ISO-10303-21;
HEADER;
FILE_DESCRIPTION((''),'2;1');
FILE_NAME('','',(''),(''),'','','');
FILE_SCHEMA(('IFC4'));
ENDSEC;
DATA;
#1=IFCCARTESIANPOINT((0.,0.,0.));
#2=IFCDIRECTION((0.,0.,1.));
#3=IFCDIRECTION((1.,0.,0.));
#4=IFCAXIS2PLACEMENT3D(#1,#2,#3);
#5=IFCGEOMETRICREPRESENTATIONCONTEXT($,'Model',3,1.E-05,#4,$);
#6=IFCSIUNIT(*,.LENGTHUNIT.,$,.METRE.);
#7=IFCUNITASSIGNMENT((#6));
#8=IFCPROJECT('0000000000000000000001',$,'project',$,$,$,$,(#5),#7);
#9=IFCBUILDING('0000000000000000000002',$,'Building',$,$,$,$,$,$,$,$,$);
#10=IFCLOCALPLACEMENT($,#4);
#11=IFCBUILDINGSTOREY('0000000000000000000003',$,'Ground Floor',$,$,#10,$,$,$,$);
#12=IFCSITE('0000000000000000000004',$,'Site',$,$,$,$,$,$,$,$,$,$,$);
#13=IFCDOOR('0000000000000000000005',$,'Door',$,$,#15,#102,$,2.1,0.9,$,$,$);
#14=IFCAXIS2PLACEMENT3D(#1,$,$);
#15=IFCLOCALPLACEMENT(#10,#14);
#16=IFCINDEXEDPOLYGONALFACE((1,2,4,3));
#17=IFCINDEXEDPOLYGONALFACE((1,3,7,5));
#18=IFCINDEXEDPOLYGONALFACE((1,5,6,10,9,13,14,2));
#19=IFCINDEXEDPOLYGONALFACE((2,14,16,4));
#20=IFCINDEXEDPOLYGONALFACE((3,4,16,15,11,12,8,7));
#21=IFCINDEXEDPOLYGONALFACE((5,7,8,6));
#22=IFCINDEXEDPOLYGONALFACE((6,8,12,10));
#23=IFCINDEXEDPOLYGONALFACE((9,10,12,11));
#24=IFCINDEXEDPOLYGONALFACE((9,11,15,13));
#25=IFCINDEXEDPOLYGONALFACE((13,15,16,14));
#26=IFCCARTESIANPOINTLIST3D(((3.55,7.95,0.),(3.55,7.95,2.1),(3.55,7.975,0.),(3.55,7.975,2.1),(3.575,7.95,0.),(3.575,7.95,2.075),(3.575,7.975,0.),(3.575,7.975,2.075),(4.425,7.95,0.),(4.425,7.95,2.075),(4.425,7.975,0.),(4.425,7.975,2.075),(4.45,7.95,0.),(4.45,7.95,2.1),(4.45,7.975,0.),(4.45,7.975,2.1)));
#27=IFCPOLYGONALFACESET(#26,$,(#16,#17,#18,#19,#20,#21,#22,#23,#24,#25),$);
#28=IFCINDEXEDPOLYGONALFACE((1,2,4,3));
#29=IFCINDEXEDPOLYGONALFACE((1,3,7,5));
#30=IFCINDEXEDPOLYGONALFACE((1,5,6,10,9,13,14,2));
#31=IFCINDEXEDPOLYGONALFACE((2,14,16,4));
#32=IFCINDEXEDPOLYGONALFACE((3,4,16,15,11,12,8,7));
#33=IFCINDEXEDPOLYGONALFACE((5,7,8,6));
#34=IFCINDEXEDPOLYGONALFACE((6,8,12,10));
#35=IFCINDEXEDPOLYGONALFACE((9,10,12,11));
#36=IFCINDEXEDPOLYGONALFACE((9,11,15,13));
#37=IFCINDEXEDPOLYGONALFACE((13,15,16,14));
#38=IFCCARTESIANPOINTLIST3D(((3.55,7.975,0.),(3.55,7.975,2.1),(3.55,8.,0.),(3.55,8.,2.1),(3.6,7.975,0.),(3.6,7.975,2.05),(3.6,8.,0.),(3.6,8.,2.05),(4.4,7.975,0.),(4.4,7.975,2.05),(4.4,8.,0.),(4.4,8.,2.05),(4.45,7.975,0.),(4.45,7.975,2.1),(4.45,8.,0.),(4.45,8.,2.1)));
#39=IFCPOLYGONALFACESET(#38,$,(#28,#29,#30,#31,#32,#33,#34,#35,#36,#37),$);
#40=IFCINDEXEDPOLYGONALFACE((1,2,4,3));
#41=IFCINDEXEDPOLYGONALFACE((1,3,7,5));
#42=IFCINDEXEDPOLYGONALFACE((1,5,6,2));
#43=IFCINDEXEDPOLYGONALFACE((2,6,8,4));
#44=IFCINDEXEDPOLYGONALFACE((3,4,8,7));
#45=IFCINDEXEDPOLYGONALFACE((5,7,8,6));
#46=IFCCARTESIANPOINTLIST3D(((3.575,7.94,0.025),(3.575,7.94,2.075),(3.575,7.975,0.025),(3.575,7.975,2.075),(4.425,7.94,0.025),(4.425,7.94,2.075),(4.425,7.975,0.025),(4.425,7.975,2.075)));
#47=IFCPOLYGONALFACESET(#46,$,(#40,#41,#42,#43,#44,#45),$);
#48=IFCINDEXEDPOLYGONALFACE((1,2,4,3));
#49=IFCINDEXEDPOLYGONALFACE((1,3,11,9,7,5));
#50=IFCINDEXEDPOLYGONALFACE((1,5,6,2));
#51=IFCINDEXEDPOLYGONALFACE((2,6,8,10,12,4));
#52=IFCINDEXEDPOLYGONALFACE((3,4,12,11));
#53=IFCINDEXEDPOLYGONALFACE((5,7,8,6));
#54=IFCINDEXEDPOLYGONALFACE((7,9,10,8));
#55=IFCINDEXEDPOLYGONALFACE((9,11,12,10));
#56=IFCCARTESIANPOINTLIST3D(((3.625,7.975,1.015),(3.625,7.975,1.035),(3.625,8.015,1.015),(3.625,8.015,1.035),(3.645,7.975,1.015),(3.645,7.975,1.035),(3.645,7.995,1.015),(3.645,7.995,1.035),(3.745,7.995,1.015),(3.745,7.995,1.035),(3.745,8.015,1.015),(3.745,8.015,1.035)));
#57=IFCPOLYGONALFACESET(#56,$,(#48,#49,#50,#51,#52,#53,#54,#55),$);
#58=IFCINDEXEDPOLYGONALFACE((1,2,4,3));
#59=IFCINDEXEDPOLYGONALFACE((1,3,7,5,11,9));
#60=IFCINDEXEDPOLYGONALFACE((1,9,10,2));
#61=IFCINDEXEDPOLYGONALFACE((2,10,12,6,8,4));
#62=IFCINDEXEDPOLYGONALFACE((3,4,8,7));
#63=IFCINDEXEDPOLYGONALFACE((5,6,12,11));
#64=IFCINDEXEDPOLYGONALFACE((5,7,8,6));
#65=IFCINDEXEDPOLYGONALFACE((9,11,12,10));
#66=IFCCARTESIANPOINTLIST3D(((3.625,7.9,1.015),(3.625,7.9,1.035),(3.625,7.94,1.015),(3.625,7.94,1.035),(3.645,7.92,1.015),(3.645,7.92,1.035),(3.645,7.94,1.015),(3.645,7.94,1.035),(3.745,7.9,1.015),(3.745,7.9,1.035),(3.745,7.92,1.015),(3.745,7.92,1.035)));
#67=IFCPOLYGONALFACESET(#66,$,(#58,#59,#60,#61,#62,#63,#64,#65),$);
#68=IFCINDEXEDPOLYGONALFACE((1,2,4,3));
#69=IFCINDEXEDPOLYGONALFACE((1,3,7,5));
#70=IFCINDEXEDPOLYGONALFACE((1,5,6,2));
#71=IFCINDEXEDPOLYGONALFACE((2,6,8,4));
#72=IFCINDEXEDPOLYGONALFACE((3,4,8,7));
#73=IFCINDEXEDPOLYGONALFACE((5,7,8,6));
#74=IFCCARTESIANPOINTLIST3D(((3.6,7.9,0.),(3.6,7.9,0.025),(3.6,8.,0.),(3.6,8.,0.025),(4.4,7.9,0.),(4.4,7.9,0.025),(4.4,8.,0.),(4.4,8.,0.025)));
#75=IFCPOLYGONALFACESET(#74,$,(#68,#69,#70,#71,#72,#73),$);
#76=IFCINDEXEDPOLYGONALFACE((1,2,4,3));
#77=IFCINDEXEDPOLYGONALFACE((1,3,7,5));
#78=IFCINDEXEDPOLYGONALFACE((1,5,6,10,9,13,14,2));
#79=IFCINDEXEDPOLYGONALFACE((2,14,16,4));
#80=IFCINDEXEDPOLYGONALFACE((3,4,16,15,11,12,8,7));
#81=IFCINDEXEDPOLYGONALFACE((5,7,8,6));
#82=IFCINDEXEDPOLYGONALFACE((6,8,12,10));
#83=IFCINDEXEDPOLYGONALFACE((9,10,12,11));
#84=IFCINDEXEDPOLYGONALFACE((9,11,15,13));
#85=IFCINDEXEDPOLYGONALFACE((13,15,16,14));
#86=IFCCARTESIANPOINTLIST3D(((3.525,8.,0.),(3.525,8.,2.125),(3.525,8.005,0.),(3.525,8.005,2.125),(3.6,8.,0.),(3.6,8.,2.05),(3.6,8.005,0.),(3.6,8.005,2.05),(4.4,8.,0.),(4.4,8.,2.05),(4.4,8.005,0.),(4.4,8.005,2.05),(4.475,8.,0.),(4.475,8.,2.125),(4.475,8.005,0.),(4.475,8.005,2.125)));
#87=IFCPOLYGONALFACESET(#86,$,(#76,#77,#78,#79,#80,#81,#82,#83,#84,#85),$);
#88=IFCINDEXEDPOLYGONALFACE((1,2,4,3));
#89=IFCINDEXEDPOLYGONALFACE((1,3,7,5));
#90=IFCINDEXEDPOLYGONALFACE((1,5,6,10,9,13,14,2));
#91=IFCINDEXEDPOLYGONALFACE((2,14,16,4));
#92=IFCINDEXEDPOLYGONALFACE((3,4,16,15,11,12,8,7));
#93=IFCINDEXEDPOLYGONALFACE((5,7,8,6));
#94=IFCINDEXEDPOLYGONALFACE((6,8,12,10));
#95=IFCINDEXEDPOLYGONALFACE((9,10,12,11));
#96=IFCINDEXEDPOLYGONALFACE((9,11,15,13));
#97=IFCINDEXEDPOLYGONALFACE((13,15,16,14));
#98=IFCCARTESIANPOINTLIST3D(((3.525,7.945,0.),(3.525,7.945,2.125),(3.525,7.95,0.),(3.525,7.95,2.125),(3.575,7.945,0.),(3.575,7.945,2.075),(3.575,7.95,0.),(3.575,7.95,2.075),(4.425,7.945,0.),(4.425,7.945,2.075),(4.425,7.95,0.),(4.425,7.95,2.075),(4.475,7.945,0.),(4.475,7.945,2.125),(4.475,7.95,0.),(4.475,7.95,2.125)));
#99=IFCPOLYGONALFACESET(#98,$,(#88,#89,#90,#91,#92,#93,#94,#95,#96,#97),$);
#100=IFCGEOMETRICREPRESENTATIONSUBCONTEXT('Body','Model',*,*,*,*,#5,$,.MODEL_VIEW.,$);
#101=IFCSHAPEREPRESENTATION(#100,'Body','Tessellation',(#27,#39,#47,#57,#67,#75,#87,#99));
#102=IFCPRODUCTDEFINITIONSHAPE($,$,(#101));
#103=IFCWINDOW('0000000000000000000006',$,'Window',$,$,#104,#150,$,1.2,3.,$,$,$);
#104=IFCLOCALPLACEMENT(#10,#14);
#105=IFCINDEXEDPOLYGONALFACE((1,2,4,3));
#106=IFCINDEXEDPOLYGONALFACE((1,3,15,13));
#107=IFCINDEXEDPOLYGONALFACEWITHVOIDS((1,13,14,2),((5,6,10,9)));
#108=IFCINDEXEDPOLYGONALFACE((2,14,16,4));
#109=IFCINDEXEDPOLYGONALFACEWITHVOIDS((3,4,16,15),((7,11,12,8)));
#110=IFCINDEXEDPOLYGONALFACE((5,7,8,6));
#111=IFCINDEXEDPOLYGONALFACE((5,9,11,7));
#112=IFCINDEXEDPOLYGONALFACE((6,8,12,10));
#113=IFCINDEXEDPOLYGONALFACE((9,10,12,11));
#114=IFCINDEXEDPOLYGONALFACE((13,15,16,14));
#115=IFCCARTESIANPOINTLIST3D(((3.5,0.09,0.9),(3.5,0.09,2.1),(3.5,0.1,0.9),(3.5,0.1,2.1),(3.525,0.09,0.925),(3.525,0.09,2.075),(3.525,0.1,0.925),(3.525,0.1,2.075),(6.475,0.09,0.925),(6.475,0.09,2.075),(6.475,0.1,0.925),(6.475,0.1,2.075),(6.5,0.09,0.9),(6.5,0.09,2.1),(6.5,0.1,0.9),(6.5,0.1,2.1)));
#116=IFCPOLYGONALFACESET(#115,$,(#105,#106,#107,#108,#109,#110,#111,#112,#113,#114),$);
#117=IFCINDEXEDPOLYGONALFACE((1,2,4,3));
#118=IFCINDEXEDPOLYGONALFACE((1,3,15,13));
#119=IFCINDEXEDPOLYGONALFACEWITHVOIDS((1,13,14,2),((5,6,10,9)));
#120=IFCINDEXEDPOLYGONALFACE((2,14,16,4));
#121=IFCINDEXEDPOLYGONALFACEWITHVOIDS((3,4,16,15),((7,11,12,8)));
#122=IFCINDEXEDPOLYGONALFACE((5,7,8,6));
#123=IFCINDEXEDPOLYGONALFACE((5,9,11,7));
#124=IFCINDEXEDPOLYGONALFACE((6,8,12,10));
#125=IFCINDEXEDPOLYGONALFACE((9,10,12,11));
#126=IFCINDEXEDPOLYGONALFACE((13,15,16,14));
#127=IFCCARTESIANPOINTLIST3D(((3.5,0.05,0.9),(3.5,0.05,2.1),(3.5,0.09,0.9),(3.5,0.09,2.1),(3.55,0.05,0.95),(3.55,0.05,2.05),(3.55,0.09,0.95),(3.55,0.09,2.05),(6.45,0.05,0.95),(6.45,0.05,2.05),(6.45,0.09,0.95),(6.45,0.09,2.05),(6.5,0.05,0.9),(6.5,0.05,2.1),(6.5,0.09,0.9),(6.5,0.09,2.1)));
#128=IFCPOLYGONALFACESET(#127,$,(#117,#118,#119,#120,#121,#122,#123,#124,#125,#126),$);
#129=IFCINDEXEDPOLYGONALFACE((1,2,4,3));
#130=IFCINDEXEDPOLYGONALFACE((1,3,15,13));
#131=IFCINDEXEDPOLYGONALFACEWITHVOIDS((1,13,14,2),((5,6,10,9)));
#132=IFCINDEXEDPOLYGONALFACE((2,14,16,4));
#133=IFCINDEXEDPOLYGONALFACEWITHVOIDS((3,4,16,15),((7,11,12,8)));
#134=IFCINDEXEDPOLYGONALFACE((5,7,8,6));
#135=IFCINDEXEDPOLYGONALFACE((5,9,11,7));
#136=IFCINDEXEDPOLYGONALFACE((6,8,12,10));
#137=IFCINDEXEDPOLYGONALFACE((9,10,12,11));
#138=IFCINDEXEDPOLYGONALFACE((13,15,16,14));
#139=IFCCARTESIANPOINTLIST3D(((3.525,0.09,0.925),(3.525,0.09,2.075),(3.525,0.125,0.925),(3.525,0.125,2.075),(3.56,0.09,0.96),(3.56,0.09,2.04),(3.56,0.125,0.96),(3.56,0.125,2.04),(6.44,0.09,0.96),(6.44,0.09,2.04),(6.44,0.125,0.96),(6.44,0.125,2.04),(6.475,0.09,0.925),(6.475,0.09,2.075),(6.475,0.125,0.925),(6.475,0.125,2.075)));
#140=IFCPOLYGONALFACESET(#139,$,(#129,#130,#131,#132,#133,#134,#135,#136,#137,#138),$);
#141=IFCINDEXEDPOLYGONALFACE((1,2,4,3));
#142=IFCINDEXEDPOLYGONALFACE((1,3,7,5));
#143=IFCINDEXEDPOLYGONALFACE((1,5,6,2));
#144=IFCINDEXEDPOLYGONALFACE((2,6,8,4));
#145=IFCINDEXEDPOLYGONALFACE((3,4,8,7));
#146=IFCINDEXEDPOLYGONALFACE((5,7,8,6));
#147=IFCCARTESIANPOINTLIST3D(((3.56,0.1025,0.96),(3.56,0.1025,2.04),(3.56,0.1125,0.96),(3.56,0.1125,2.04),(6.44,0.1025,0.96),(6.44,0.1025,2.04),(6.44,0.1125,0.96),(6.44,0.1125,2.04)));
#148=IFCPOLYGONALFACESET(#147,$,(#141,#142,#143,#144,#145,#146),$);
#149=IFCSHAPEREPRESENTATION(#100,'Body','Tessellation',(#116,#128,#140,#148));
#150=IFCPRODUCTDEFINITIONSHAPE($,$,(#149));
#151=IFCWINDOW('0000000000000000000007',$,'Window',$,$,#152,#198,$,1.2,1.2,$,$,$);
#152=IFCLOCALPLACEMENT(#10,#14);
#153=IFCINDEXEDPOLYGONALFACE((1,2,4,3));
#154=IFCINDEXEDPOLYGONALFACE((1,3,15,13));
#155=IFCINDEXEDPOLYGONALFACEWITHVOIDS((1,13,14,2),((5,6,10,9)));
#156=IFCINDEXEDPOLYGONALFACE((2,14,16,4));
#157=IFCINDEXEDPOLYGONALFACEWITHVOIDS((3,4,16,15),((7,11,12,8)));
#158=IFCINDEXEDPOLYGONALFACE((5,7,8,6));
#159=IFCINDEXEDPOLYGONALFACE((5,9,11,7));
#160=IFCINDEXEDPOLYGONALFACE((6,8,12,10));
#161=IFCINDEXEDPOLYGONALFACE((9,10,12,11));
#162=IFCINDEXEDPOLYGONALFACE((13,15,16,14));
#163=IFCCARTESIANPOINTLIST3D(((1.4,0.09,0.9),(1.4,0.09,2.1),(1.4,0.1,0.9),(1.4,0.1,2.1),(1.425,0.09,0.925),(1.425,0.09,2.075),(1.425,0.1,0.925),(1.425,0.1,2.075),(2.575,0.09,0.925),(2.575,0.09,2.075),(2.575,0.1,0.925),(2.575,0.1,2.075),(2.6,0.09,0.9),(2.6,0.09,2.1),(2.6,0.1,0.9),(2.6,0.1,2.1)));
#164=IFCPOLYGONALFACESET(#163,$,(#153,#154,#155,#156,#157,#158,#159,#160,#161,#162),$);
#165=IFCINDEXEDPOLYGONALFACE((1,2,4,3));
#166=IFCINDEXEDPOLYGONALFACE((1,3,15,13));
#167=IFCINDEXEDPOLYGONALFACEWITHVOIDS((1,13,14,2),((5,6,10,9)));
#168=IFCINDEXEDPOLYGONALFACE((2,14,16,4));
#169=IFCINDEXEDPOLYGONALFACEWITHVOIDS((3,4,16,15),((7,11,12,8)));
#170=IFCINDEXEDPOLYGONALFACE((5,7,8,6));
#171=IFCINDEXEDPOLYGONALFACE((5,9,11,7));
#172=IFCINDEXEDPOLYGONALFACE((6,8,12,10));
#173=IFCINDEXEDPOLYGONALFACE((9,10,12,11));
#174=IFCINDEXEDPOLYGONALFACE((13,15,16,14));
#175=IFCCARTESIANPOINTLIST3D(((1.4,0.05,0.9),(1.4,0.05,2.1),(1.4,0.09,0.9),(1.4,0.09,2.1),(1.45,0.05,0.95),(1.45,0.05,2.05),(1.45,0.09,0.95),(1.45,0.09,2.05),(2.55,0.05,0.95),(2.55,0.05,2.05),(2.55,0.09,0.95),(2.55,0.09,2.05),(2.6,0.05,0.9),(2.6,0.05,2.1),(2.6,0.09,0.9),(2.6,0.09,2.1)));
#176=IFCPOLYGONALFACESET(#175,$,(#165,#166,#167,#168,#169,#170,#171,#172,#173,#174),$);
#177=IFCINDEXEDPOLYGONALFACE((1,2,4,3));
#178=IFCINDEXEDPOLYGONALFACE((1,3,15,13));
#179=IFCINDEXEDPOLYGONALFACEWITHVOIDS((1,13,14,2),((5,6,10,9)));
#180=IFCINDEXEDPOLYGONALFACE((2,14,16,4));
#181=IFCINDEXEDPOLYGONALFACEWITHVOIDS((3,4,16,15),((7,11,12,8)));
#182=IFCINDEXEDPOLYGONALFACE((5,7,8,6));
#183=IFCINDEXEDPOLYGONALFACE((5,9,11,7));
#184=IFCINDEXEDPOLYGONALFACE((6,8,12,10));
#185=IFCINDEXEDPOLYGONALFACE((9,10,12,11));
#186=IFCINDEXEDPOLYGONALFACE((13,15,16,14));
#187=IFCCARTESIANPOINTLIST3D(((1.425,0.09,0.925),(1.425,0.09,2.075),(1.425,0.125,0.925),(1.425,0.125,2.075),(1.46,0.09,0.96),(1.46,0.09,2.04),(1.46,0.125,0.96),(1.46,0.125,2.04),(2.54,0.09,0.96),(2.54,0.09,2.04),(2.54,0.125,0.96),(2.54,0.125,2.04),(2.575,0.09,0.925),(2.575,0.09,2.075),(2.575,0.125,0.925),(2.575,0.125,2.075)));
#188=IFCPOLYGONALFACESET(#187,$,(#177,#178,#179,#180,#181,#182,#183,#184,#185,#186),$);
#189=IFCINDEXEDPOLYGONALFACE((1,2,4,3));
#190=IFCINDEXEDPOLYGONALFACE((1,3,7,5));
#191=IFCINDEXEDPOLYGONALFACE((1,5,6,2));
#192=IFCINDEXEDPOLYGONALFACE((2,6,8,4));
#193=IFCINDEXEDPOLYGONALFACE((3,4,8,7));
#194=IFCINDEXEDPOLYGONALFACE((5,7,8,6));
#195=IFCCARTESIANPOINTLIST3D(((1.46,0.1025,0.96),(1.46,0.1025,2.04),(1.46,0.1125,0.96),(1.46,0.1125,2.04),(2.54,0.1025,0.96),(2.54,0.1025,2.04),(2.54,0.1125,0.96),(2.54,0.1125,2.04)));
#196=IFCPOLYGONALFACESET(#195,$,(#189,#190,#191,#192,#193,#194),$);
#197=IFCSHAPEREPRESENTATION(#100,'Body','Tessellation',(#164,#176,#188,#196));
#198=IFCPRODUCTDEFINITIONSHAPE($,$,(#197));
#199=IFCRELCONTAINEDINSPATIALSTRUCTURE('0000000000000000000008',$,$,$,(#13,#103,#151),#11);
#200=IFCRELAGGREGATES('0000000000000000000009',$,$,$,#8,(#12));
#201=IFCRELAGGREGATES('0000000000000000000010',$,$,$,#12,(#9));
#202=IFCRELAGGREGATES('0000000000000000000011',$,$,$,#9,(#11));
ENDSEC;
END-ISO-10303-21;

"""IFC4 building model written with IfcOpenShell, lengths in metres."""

from ifc_helpers import new_model, si_unit, frame, origin_with_axes, place, context, subcontext, project, spatial, line, indexed_curve, outline, extrude, element, save


model = new_model("IFC4")

# Units and contexts
model_context = context("Model", 3, precision=1e-05, world=origin_with_axes())
body_context = subcontext(model_context, "Body", "Model", "MODEL_VIEW")
ifc_project = project(units=[si_unit("LENGTHUNIT", "METRE")], contexts=[model_context])

# Site, building, storey
site = spatial("IfcSite", under=ifc_project, Name="Site")
building = spatial("IfcBuilding", under=site, Name="Building")
storey_placement = place(None, origin_with_axes())
storey = spatial("IfcBuildingStorey", under=building, at=storey_placement, Name="Ground Floor")

# Door
door_1_placement = place(storey_placement, frame((4.45, 8.0, 0.0), z_axis=(0.0, 0.0, 1.0), x_axis=(-1.0, 0.0, 0.0)))
element("IfcDoor", 1, at=door_1_placement, inside=storey, Name="Door", OverallHeight=2.1, OverallWidth=0.9, context=body_context, shape_type="SweptSolid", body=[
    extrude(outline(indexed_curve([(0.0, 0.0), (0.0, 2.1), (0.9, 2.1), (0.9, 0.0), (0.875, 0.0), (0.875, 2.075), (0.025, 2.075), (0.025, 0.0)], segments=[line(1, 2, 3, 4, 5, 6, 7, 8, 1)])), frame((0.0, 0.025, 0.0), z_axis=(0.0, -1.0, 0.0), x_axis=(1.0, 0.0, 0.0)), (0.0, 0.0, -1.0), 0.025),
    extrude(outline(indexed_curve([(0.0, 0.0), (0.0, 2.1), (0.9, 2.1), (0.9, 0.0), (0.85, 0.0), (0.85, 2.05), (0.05, 2.05), (0.05, 0.0)], segments=[line(1, 2, 3, 4, 5, 6, 7, 8, 1)])), frame((0.0, 0.0, 0.0), z_axis=(0.0, -1.0, 0.0), x_axis=(1.0, 0.0, 0.0)), (0.0, 0.0, -1.0), 0.025),
    extrude(outline(indexed_curve([(0.0, 0.0), (0.85, 0.0), (0.85, 0.035), (0.0, 0.035)], segments=[line(1, 2, 3, 4, 1)])), frame((0.025, 0.025, 0.025), z_axis=(0.0, 0.0, 1.0), x_axis=(1.0, 0.0, 0.0)), (0.0, 0.0, 1.0), 2.05),
    extrude(outline(indexed_curve([(0.0, 0.0), (0.0, -0.04), (-0.12, -0.04), (-0.12, -0.02), (-0.02, -0.02), (-0.02, 0.0)], segments=[line(1, 2, 3, 4, 5, 6, 1)])), frame((0.825, 0.025, 1.015), z_axis=(0.0, 0.0, 1.0), x_axis=(1.0, 0.0, 0.0)), (0.0, 0.0, 1.0), 0.02),
    extrude(outline(indexed_curve([(0.0, 0.0), (0.0, 0.04), (-0.12, 0.04), (-0.12, 0.02), (-0.02, 0.02), (-0.02, 0.0)], segments=[line(1, 2, 3, 4, 5, 6, 1)])), frame((0.825, 0.06, 1.015), z_axis=(0.0, 0.0, 1.0), x_axis=(1.0, 0.0, 0.0)), (0.0, 0.0, 1.0), 0.02),
    extrude(outline(indexed_curve([(0.0, 0.0), (0.8, 0.0), (0.8, 0.1), (0.0, 0.1)], segments=[line(1, 2, 3, 4, 1)])), frame((0.05, 0.0, 0.0), z_axis=(0.0, 0.0, 1.0), x_axis=(1.0, 0.0, 0.0)), (0.0, 0.0, 1.0), 0.025),
    extrude(outline(indexed_curve([(0.0, 0.0), (0.0, 2.125), (0.95, 2.125), (0.95, 0.0), (0.875, 0.0), (0.875, 2.05), (0.075, 2.05), (0.075, 0.0)], segments=[line(1, 2, 3, 4, 5, 6, 7, 8, 1)])), frame((-0.025, -0.005, 0.0), z_axis=(0.0, -1.0, 0.0), x_axis=(1.0, 0.0, 0.0)), (0.0, 0.0, -1.0), 0.005),
    extrude(outline(indexed_curve([(0.0, 0.0), (0.0, 2.125), (0.95, 2.125), (0.95, 0.0), (0.9, 0.0), (0.9, 2.075), (0.05, 2.075), (0.05, 0.0)], segments=[line(1, 2, 3, 4, 5, 6, 7, 8, 1)])), frame((-0.025, 0.05, 0.0), z_axis=(0.0, -1.0, 0.0), x_axis=(1.0, 0.0, 0.0)), (0.0, 0.0, -1.0), 0.005),
])

# Windows
window_1_placement = place(storey_placement, frame((3.5, 0.0, 0.9), z_axis=(0.0, 0.0, 1.0), x_axis=(1.0, 0.0, 0.0)))
element("IfcWindow", 2, at=window_1_placement, inside=storey, Name="Window", OverallHeight=1.2, OverallWidth=3.0, context=body_context, shape_type="SweptSolid", body=[
    extrude(outline(indexed_curve([(0.0, 0.0), (3.0, 0.0), (3.0, 1.2), (0.0, 1.2)], segments=[line(1, 2, 3, 4, 1)]), holes=[indexed_curve([(0.025, 0.025), (2.975, 0.025), (2.975, 1.175), (0.025, 1.175)], segments=[line(1, 2, 3, 4, 1)])]), frame((0.0, 0.09, 0.0), z_axis=(0.0, -1.0, 0.0), x_axis=(1.0, 0.0, 0.0)), (0.0, 0.0, -1.0), 0.01),
    extrude(outline(indexed_curve([(0.0, 0.0), (3.0, 0.0), (3.0, 1.2), (0.0, 1.2)], segments=[line(1, 2, 3, 4, 1)]), holes=[indexed_curve([(0.05, 0.05), (2.95, 0.05), (2.95, 1.15), (0.05, 1.15)], segments=[line(1, 2, 3, 4, 1)])]), frame((0.0, 0.05, 0.0), z_axis=(0.0, -1.0, 0.0), x_axis=(1.0, 0.0, 0.0)), (0.0, 0.0, -1.0), 0.04),
    extrude(outline(indexed_curve([(0.0, 0.0), (2.95, 0.0), (2.95, 1.15), (0.0, 1.15)], segments=[line(1, 2, 3, 4, 1)]), holes=[indexed_curve([(0.035, 0.035), (2.915, 0.035), (2.915, 1.115), (0.035, 1.115)], segments=[line(1, 2, 3, 4, 1)])]), frame((0.025, 0.09, 0.025), z_axis=(0.0, -1.0, 0.0), x_axis=(1.0, 0.0, 0.0)), (0.0, 0.0, -1.0), 0.035),
    extrude(outline(indexed_curve([(0.035, 0.035), (2.915, 0.035), (2.915, 1.115), (0.035, 1.115)], segments=[line(1, 2, 3, 4, 1)])), frame((0.025, 0.1025, 0.025), z_axis=(0.0, -1.0, 0.0), x_axis=(1.0, 0.0, 0.0)), (0.0, 0.0, -1.0), 0.01),
])
window_2_placement = place(storey_placement, frame((1.4, 0.0, 0.9), z_axis=(0.0, 0.0, 1.0), x_axis=(1.0, 0.0, 0.0)))
element("IfcWindow", 3, at=window_2_placement, inside=storey, Name="Window", OverallHeight=1.2, OverallWidth=1.2, context=body_context, shape_type="SweptSolid", body=[
    extrude(outline(indexed_curve([(0.0, 0.0), (1.2, 0.0), (1.2, 1.2), (0.0, 1.2)], segments=[line(1, 2, 3, 4, 1)]), holes=[indexed_curve([(0.025, 0.025), (1.175, 0.025), (1.175, 1.175), (0.025, 1.175)], segments=[line(1, 2, 3, 4, 1)])]), frame((0.0, 0.09, 0.0), z_axis=(0.0, -1.0, 0.0), x_axis=(1.0, 0.0, 0.0)), (0.0, 0.0, -1.0), 0.01),
    extrude(outline(indexed_curve([(0.0, 0.0), (1.2, 0.0), (1.2, 1.2), (0.0, 1.2)], segments=[line(1, 2, 3, 4, 1)]), holes=[indexed_curve([(0.05, 0.05), (1.15, 0.05), (1.15, 1.15), (0.05, 1.15)], segments=[line(1, 2, 3, 4, 1)])]), frame((0.0, 0.05, 0.0), z_axis=(0.0, -1.0, 0.0), x_axis=(1.0, 0.0, 0.0)), (0.0, 0.0, -1.0), 0.04),
    extrude(outline(indexed_curve([(0.0, 0.0), (1.15, 0.0), (1.15, 1.15), (0.0, 1.15)], segments=[line(1, 2, 3, 4, 1)]), holes=[indexed_curve([(0.035, 0.035), (1.115, 0.035), (1.115, 1.115), (0.035, 1.115)], segments=[line(1, 2, 3, 4, 1)])]), frame((0.025, 0.09, 0.025), z_axis=(0.0, -1.0, 0.0), x_axis=(1.0, 0.0, 0.0)), (0.0, 0.0, -1.0), 0.035),
    extrude(outline(indexed_curve([(0.035, 0.035), (1.115, 0.035), (1.115, 1.115), (0.035, 1.115)], segments=[line(1, 2, 3, 4, 1)])), frame((0.025, 0.1025, 0.025), z_axis=(0.0, -1.0, 0.0), x_axis=(1.0, 0.0, 0.0)), (0.0, 0.0, -1.0), 0.01),
])

save(model, "model.ifc")
